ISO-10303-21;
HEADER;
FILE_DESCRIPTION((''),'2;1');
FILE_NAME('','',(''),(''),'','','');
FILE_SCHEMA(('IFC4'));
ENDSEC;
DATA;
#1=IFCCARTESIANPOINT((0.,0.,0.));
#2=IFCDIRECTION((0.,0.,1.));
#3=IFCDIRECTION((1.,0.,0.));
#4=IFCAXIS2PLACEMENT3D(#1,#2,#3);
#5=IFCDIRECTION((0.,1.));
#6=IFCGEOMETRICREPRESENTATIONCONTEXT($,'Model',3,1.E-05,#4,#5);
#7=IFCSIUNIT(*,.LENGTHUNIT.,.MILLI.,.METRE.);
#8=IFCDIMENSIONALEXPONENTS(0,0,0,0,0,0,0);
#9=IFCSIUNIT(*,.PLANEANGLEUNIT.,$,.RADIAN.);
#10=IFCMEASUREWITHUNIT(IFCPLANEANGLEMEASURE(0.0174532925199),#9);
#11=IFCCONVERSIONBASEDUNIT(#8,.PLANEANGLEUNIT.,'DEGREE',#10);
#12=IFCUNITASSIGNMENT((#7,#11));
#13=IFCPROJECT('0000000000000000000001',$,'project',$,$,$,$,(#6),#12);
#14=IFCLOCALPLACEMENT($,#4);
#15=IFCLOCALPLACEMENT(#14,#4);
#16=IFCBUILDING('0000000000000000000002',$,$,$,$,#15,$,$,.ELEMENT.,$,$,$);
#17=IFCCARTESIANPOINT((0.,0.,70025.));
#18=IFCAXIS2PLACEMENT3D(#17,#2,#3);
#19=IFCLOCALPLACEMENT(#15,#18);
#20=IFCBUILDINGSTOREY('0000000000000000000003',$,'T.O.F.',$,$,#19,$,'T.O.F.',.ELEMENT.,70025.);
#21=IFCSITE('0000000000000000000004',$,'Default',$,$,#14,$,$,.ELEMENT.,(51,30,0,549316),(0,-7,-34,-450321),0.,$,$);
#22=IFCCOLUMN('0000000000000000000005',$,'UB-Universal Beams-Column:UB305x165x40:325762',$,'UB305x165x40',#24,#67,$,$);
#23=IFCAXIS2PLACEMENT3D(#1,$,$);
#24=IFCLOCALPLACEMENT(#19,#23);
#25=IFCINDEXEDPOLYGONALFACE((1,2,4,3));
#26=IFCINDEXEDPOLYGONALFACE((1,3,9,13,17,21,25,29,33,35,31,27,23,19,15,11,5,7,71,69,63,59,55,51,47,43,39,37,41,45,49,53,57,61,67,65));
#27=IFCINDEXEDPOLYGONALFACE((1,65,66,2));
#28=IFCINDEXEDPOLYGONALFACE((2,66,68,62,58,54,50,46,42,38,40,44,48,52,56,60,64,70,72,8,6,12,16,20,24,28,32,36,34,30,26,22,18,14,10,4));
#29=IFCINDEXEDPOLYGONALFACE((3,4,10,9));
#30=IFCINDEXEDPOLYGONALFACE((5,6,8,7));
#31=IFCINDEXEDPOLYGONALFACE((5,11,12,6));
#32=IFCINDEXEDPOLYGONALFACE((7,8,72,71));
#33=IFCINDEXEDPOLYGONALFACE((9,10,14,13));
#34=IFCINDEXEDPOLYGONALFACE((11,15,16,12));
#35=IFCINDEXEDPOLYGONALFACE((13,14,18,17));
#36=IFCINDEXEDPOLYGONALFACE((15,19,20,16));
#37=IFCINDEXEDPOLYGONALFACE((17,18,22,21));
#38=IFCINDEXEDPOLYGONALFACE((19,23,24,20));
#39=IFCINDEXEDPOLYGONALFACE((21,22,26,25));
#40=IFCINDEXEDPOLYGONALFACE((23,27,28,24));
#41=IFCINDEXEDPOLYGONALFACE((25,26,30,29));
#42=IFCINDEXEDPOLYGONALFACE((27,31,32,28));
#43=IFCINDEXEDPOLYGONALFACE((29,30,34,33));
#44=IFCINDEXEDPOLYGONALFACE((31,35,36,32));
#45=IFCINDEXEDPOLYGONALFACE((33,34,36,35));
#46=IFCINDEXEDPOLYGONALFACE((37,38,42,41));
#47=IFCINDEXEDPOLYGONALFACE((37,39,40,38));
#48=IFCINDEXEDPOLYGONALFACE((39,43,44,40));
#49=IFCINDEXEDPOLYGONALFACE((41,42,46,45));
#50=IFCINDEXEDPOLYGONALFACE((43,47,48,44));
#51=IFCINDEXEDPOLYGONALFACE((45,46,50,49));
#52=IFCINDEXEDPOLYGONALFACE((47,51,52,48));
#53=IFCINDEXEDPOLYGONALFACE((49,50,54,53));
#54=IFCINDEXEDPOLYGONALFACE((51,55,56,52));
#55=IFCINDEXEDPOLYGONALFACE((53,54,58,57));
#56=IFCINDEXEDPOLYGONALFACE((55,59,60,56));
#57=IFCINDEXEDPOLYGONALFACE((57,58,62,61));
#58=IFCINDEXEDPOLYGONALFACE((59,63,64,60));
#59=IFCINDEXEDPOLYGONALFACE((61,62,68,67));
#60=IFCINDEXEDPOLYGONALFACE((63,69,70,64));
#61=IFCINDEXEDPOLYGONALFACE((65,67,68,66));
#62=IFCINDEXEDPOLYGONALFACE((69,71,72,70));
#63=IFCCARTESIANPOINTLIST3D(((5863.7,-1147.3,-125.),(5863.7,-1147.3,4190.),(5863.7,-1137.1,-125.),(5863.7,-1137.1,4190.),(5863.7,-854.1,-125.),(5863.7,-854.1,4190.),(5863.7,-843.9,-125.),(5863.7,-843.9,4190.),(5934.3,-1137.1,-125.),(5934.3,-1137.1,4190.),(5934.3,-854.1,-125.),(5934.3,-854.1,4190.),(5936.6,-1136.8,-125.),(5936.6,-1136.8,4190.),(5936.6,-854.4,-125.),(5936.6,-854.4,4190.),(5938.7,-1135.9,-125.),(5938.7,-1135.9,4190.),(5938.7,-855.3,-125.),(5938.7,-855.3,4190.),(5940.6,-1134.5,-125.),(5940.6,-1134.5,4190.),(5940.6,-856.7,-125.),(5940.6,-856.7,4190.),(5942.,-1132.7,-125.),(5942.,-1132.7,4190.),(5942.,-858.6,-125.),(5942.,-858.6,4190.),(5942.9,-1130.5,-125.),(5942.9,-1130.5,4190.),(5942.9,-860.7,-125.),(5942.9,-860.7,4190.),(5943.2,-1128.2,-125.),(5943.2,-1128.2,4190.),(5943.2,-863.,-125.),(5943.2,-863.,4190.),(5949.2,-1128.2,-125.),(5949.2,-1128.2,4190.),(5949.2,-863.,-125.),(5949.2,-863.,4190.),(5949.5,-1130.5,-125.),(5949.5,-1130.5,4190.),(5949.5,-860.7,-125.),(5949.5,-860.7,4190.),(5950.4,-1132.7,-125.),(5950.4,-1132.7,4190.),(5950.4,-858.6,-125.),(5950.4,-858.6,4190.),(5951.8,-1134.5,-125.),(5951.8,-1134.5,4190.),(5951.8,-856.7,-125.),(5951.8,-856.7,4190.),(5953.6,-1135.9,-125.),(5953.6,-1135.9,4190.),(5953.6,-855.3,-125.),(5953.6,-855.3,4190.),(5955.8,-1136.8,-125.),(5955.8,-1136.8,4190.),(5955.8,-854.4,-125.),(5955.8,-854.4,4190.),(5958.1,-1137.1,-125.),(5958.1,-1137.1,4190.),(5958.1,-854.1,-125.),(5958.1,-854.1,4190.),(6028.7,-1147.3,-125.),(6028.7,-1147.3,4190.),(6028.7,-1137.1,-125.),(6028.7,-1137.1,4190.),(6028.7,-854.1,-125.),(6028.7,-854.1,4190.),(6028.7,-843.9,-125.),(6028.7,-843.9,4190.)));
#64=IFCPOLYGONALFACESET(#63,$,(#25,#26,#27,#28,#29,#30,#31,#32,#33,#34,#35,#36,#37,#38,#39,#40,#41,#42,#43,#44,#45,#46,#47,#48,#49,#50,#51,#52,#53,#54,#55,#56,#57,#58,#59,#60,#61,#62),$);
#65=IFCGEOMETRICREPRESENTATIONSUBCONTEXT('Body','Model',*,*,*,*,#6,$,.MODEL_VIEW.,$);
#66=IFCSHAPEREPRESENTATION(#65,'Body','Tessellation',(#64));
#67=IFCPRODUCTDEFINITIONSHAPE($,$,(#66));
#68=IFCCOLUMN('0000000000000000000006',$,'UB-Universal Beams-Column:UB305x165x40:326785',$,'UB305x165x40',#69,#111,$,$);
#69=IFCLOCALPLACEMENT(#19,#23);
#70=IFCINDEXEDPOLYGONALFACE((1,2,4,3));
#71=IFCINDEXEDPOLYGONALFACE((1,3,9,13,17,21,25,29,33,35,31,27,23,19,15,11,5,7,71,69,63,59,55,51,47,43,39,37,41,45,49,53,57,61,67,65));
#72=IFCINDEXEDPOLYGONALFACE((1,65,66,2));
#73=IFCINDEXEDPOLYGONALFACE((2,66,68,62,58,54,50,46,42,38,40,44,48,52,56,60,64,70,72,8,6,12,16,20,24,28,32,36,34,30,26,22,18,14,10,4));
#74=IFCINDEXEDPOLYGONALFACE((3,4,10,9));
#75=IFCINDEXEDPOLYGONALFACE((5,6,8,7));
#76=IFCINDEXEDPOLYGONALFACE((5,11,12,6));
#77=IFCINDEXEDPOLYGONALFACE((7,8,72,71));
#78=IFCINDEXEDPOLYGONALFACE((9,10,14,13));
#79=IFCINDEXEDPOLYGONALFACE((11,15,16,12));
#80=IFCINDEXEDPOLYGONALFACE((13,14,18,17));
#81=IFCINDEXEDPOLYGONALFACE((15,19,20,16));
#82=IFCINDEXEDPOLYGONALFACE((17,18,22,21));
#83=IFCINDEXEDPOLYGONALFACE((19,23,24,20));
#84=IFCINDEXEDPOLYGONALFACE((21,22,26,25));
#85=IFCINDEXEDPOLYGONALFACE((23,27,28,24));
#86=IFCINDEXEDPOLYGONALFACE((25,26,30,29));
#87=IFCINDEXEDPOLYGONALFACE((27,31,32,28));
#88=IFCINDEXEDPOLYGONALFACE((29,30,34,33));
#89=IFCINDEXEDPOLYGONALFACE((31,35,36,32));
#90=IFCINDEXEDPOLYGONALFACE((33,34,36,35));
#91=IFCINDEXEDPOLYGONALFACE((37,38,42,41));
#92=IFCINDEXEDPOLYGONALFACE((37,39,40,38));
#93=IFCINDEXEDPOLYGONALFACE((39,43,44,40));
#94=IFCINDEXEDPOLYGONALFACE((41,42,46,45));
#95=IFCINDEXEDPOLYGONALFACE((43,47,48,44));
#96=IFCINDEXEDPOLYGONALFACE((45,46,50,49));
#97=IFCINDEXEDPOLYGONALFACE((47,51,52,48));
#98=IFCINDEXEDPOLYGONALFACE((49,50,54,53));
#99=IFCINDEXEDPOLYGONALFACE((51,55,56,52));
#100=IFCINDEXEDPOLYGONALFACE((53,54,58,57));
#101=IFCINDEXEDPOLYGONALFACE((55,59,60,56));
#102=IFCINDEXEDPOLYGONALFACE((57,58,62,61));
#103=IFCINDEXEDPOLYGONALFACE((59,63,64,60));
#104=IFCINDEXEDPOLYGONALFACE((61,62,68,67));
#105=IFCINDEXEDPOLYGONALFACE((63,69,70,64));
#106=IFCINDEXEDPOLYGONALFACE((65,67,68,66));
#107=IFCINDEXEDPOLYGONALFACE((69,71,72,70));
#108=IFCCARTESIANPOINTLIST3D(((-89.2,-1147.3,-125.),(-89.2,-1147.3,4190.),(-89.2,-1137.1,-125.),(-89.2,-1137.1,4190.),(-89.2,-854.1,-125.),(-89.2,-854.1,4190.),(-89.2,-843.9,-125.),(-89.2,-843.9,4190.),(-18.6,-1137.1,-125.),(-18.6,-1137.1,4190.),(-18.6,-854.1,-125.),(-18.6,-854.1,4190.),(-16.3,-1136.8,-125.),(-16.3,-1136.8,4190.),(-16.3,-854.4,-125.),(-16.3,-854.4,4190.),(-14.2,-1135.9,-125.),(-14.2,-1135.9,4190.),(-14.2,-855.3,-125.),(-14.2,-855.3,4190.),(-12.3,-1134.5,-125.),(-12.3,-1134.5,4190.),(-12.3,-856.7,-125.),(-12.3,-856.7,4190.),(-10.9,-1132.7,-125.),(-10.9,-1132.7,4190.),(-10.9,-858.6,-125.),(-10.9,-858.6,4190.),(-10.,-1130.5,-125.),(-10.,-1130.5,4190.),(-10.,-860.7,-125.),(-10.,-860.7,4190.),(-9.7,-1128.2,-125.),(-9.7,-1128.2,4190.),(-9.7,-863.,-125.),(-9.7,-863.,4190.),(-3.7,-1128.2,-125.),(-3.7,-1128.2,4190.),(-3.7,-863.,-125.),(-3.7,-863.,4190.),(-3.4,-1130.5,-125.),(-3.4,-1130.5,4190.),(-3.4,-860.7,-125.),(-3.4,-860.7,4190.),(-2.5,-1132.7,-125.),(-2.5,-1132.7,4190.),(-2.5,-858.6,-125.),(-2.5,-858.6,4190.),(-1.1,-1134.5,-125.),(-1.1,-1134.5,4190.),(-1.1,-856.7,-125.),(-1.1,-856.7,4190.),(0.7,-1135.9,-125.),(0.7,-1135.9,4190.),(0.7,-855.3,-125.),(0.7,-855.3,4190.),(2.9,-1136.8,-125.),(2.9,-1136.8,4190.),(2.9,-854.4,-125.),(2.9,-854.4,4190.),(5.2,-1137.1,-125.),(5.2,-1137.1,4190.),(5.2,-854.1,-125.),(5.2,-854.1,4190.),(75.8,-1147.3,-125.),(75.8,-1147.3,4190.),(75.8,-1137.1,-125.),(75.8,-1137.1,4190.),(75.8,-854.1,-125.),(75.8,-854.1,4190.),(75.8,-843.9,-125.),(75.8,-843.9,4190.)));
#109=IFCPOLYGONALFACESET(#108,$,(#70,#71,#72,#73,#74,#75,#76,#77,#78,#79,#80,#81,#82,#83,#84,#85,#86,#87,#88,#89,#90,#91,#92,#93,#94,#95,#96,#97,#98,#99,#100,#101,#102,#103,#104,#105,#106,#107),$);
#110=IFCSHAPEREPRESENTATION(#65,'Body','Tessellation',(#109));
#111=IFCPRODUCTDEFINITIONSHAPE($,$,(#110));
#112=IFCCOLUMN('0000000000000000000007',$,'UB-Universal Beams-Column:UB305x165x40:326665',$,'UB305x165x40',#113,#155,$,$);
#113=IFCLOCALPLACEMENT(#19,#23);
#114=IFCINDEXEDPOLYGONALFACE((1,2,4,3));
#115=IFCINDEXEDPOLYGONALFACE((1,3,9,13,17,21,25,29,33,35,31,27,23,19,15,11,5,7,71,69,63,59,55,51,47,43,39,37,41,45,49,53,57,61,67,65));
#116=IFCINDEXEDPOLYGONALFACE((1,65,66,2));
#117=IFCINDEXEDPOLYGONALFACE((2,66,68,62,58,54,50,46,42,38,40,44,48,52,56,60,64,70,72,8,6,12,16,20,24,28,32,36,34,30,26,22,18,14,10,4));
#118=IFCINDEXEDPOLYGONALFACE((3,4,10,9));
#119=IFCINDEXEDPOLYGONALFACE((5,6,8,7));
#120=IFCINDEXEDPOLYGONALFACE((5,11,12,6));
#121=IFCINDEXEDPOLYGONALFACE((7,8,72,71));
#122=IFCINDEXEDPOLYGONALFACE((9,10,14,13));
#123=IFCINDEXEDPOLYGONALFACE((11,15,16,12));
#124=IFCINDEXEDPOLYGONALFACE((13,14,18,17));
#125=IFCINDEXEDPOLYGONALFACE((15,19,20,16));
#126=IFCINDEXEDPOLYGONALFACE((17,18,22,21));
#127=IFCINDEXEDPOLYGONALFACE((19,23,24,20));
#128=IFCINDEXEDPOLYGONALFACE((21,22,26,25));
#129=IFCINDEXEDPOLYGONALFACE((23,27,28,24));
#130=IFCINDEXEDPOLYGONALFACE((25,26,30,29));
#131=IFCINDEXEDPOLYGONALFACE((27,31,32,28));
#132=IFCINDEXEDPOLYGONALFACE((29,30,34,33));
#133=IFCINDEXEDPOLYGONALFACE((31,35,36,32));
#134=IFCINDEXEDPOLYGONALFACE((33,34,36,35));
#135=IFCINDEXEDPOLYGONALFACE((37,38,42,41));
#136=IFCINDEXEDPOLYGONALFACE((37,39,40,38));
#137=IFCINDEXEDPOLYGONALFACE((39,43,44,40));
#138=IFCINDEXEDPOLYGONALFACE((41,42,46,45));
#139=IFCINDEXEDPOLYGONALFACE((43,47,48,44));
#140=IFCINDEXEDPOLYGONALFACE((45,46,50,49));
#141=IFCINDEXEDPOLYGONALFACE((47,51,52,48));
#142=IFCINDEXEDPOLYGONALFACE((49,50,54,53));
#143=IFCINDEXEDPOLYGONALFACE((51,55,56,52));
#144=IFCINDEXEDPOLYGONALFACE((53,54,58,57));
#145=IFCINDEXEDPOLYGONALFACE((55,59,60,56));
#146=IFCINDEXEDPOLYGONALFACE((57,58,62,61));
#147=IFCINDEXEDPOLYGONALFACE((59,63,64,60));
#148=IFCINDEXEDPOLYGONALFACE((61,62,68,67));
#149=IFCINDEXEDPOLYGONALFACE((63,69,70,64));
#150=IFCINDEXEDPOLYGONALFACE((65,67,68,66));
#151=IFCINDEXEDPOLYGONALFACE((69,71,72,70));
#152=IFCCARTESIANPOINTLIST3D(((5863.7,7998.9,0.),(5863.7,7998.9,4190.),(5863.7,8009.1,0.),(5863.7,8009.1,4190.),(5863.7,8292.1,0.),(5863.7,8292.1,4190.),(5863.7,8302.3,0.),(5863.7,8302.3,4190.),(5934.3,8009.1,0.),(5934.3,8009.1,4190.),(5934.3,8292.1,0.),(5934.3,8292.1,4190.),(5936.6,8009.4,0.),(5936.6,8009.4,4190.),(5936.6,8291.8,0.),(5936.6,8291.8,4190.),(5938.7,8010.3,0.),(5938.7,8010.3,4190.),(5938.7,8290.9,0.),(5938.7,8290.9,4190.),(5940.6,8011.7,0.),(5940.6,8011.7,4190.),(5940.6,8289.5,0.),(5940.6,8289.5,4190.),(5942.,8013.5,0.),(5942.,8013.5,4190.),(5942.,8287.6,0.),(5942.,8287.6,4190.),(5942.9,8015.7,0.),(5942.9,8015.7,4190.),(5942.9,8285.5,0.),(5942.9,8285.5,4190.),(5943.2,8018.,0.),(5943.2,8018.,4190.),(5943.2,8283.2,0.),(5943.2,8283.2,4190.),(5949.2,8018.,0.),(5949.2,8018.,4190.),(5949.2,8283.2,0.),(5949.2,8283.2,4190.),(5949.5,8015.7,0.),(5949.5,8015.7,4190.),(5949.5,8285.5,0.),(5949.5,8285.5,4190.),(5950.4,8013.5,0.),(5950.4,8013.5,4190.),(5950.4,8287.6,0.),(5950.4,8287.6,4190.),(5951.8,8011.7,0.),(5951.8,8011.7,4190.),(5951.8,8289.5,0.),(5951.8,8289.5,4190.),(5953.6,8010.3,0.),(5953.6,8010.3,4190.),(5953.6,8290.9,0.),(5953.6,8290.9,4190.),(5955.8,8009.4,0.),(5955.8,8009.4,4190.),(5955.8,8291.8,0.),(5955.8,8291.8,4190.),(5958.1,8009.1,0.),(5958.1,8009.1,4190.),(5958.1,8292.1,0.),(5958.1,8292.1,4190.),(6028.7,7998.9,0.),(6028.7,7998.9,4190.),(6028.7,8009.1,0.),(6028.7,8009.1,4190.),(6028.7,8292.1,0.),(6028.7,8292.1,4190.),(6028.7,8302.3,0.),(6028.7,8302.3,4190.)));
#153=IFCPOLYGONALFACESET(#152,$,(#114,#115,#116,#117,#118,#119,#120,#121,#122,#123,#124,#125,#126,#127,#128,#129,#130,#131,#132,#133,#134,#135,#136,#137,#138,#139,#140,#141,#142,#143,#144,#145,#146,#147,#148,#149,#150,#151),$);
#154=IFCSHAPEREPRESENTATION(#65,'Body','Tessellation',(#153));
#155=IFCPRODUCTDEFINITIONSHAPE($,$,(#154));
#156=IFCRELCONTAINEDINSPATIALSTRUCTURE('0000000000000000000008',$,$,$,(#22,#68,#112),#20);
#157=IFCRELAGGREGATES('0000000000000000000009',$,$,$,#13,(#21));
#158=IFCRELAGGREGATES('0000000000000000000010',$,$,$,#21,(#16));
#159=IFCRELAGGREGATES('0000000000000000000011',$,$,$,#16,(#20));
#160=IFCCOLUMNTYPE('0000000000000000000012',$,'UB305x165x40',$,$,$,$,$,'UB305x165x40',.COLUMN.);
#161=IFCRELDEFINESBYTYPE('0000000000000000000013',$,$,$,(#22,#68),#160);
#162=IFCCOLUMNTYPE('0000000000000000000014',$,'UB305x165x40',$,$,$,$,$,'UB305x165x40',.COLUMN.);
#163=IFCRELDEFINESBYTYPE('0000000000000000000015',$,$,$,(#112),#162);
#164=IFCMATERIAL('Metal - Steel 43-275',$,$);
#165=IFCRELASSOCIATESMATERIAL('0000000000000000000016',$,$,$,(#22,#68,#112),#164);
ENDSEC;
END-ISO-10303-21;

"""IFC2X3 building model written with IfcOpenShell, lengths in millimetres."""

from ifc_helpers import new_model, entity, si_unit, converted_unit, point, direction, frame, frame_2d, origin_with_axes, place, context, subcontext, project, spatial, polyline, circle_curve, parameter, trimmed, segment, composite_curve, outline, extrude, material, type_object, element, save


model = new_model("IFC2X3")

# Units and contexts
model_context = context("Model", 3, precision=1e-05, world=origin_with_axes(), true_north=direction((0.0, 1.0)))
body_context = subcontext(model_context, "Body", "Model", "MODEL_VIEW")
ifc_project = project(units=[si_unit("LENGTHUNIT", "METRE", prefix="MILLI"), converted_unit("PLANEANGLEUNIT", "DEGREE", entity("IfcPlaneAngleMeasure", 0.0174532925199), si_unit("PLANEANGLEUNIT", "RADIAN"), dimensions=[0, 0, 0, 0, 0, 0, 0])], contexts=[model_context])

# Site, building, storey
site_placement = place(None, origin_with_axes())
site = spatial("IfcSite", under=ifc_project, at=site_placement, Name="Default", CompositionType="ELEMENT", RefLatitude=(51, 30, 0, 549316), RefLongitude=(0, -7, -34, -450321), RefElevation=0.0)
building_placement = place(site_placement, origin_with_axes())
building = spatial("IfcBuilding", under=site, at=building_placement, CompositionType="ELEMENT")
storey_placement = place(building_placement, frame((0.0, 0.0, 70025.0), z_axis=(0.0, 0.0, 1.0), x_axis=(1.0, 0.0, 0.0)))
storey = spatial("IfcBuildingStorey", under=building, at=storey_placement, Name="T.O.F.", LongName="T.O.F.", CompositionType="ELEMENT", Elevation=70025.0)

# Columns
ifc_material_1 = material(Name="Metal - Steel 43-275")
column_type_1 = type_object("IfcColumnType", Name="UB305x165x40", ElementType="UB305x165x40", PredefinedType="COLUMN")
for number, where, z_axis, x_axis, name in (
    (1, (5946.2, -995.6, -125.0), (0.0, 0.0, 1.0), (0.0, -1.0, 0.0), "UB-Universal Beams-Column:UB305x165x40:325762"),
    (2, (-6.7, -995.6, -125.0), (0.0, 0.0, 1.0), (0.0, -1.0, 0.0), "UB-Universal Beams-Column:UB305x165x40:326785"),
):
    element("IfcColumn", number, at=place(storey_placement, frame(where, z_axis=z_axis, x_axis=x_axis)), inside=storey, type_object=column_type_1, material=ifc_material_1, Name=name, ObjectType="UB305x165x40", context=body_context, shape_type="SweptSolid", body=[
        extrude(outline(composite_curve([segment(polyline([(141.5, -82.5), (151.7, -82.5), (151.7, 82.5), (141.5, 82.5), (141.5, 11.9)]), True, "CONTINUOUS"), segment(trimmed(circle_curve(frame_2d((132.6, 11.9), x_axis=(0.0, -1.0)), 8.9), [point((141.5, 11.9)), parameter(90.0)], [point((132.6, 3.0)), parameter(0.0)], False, "CARTESIAN"), True, "CONTINUOUS"), segment(polyline([(132.6, 3.0), (-132.6, 3.0)]), True, "CONTINUOUS"), segment(trimmed(circle_curve(frame_2d((-132.6, 11.9), x_axis=(-1.0, 0.0)), 8.9), [point((-132.6, 3.0)), parameter(90.0)], [point((-141.5, 11.9)), parameter(0.0)], False, "CARTESIAN"), True, "CONTINUOUS"), segment(polyline([(-141.5, 11.9), (-141.5, 82.5), (-151.7, 82.5), (-151.7, -82.5), (-141.5, -82.5), (-141.5, -11.9)]), True, "CONTINUOUS"), segment(trimmed(circle_curve(frame_2d((-132.6, -11.9), x_axis=(0.0, 1.0)), 8.9), [point((-141.5, -11.9)), parameter(90.0)], [point((-132.6, -3.0)), parameter(0.0)], False, "CARTESIAN"), True, "CONTINUOUS"), segment(polyline([(-132.6, -3.0), (132.6, -3.0)]), True, "CONTINUOUS"), segment(trimmed(circle_curve(frame_2d((132.6, -11.9), x_axis=(1.0, 0.0)), 8.9), [point((132.6, -3.0)), parameter(90.0)], [point((141.5, -11.9)), parameter(0.0)], False, "CARTESIAN"), True, "CONTINUOUS"), segment(polyline([(141.5, -11.9), (141.5, -82.5)]), True, "CONTINUOUS")], self_intersect=False)), origin_with_axes(), (0.0, 0.0, 1.0), 4315.0),
    ])
column_type_2 = type_object("IfcColumnType", Name="UB305x165x40", ElementType="UB305x165x40", PredefinedType="COLUMN")
for number, where, z_axis, x_axis, name in (
    (3, (5946.2, 8150.6, 0.0), (0.0, 0.0, 1.0), (0.0, -1.0, 0.0), "UB-Universal Beams-Column:UB305x165x40:326665"),
):
    element("IfcColumn", number, at=place(storey_placement, frame(where, z_axis=z_axis, x_axis=x_axis)), inside=storey, type_object=column_type_2, material=ifc_material_1, Name=name, ObjectType="UB305x165x40", context=body_context, shape_type="SweptSolid", body=[
        extrude(outline(composite_curve([segment(polyline([(141.5, -82.5), (151.7, -82.5), (151.7, 82.5), (141.5, 82.5), (141.5, 11.9)]), True, "CONTINUOUS"), segment(trimmed(circle_curve(frame_2d((132.6, 11.9), x_axis=(0.0, -1.0)), 8.9), [point((141.5, 11.9)), parameter(90.0)], [point((132.6, 3.0)), parameter(0.0)], False, "CARTESIAN"), True, "CONTINUOUS"), segment(polyline([(132.6, 3.0), (-132.6, 3.0)]), True, "CONTINUOUS"), segment(trimmed(circle_curve(frame_2d((-132.6, 11.9), x_axis=(-1.0, 0.0)), 8.9), [point((-132.6, 3.0)), parameter(90.0)], [point((-141.5, 11.9)), parameter(0.0)], False, "CARTESIAN"), True, "CONTINUOUS"), segment(polyline([(-141.5, 11.9), (-141.5, 82.5), (-151.7, 82.5), (-151.7, -82.5), (-141.5, -82.5), (-141.5, -11.9)]), True, "CONTINUOUS"), segment(trimmed(circle_curve(frame_2d((-132.6, -11.9), x_axis=(0.0, 1.0)), 8.9), [point((-141.5, -11.9)), parameter(90.0)], [point((-132.6, -3.0)), parameter(0.0)], False, "CARTESIAN"), True, "CONTINUOUS"), segment(polyline([(-132.6, -3.0), (132.6, -3.0)]), True, "CONTINUOUS"), segment(trimmed(circle_curve(frame_2d((132.6, -11.9), x_axis=(1.0, 0.0)), 8.9), [point((132.6, -3.0)), parameter(90.0)], [point((141.5, -11.9)), parameter(0.0)], False, "CARTESIAN"), True, "CONTINUOUS"), segment(polyline([(141.5, -11.9), (141.5, -82.5)]), True, "CONTINUOUS")], self_intersect=False)), origin_with_axes(), (0.0, 0.0, 1.0), 4190.0),
    ])

save(model, "model.ifc")
